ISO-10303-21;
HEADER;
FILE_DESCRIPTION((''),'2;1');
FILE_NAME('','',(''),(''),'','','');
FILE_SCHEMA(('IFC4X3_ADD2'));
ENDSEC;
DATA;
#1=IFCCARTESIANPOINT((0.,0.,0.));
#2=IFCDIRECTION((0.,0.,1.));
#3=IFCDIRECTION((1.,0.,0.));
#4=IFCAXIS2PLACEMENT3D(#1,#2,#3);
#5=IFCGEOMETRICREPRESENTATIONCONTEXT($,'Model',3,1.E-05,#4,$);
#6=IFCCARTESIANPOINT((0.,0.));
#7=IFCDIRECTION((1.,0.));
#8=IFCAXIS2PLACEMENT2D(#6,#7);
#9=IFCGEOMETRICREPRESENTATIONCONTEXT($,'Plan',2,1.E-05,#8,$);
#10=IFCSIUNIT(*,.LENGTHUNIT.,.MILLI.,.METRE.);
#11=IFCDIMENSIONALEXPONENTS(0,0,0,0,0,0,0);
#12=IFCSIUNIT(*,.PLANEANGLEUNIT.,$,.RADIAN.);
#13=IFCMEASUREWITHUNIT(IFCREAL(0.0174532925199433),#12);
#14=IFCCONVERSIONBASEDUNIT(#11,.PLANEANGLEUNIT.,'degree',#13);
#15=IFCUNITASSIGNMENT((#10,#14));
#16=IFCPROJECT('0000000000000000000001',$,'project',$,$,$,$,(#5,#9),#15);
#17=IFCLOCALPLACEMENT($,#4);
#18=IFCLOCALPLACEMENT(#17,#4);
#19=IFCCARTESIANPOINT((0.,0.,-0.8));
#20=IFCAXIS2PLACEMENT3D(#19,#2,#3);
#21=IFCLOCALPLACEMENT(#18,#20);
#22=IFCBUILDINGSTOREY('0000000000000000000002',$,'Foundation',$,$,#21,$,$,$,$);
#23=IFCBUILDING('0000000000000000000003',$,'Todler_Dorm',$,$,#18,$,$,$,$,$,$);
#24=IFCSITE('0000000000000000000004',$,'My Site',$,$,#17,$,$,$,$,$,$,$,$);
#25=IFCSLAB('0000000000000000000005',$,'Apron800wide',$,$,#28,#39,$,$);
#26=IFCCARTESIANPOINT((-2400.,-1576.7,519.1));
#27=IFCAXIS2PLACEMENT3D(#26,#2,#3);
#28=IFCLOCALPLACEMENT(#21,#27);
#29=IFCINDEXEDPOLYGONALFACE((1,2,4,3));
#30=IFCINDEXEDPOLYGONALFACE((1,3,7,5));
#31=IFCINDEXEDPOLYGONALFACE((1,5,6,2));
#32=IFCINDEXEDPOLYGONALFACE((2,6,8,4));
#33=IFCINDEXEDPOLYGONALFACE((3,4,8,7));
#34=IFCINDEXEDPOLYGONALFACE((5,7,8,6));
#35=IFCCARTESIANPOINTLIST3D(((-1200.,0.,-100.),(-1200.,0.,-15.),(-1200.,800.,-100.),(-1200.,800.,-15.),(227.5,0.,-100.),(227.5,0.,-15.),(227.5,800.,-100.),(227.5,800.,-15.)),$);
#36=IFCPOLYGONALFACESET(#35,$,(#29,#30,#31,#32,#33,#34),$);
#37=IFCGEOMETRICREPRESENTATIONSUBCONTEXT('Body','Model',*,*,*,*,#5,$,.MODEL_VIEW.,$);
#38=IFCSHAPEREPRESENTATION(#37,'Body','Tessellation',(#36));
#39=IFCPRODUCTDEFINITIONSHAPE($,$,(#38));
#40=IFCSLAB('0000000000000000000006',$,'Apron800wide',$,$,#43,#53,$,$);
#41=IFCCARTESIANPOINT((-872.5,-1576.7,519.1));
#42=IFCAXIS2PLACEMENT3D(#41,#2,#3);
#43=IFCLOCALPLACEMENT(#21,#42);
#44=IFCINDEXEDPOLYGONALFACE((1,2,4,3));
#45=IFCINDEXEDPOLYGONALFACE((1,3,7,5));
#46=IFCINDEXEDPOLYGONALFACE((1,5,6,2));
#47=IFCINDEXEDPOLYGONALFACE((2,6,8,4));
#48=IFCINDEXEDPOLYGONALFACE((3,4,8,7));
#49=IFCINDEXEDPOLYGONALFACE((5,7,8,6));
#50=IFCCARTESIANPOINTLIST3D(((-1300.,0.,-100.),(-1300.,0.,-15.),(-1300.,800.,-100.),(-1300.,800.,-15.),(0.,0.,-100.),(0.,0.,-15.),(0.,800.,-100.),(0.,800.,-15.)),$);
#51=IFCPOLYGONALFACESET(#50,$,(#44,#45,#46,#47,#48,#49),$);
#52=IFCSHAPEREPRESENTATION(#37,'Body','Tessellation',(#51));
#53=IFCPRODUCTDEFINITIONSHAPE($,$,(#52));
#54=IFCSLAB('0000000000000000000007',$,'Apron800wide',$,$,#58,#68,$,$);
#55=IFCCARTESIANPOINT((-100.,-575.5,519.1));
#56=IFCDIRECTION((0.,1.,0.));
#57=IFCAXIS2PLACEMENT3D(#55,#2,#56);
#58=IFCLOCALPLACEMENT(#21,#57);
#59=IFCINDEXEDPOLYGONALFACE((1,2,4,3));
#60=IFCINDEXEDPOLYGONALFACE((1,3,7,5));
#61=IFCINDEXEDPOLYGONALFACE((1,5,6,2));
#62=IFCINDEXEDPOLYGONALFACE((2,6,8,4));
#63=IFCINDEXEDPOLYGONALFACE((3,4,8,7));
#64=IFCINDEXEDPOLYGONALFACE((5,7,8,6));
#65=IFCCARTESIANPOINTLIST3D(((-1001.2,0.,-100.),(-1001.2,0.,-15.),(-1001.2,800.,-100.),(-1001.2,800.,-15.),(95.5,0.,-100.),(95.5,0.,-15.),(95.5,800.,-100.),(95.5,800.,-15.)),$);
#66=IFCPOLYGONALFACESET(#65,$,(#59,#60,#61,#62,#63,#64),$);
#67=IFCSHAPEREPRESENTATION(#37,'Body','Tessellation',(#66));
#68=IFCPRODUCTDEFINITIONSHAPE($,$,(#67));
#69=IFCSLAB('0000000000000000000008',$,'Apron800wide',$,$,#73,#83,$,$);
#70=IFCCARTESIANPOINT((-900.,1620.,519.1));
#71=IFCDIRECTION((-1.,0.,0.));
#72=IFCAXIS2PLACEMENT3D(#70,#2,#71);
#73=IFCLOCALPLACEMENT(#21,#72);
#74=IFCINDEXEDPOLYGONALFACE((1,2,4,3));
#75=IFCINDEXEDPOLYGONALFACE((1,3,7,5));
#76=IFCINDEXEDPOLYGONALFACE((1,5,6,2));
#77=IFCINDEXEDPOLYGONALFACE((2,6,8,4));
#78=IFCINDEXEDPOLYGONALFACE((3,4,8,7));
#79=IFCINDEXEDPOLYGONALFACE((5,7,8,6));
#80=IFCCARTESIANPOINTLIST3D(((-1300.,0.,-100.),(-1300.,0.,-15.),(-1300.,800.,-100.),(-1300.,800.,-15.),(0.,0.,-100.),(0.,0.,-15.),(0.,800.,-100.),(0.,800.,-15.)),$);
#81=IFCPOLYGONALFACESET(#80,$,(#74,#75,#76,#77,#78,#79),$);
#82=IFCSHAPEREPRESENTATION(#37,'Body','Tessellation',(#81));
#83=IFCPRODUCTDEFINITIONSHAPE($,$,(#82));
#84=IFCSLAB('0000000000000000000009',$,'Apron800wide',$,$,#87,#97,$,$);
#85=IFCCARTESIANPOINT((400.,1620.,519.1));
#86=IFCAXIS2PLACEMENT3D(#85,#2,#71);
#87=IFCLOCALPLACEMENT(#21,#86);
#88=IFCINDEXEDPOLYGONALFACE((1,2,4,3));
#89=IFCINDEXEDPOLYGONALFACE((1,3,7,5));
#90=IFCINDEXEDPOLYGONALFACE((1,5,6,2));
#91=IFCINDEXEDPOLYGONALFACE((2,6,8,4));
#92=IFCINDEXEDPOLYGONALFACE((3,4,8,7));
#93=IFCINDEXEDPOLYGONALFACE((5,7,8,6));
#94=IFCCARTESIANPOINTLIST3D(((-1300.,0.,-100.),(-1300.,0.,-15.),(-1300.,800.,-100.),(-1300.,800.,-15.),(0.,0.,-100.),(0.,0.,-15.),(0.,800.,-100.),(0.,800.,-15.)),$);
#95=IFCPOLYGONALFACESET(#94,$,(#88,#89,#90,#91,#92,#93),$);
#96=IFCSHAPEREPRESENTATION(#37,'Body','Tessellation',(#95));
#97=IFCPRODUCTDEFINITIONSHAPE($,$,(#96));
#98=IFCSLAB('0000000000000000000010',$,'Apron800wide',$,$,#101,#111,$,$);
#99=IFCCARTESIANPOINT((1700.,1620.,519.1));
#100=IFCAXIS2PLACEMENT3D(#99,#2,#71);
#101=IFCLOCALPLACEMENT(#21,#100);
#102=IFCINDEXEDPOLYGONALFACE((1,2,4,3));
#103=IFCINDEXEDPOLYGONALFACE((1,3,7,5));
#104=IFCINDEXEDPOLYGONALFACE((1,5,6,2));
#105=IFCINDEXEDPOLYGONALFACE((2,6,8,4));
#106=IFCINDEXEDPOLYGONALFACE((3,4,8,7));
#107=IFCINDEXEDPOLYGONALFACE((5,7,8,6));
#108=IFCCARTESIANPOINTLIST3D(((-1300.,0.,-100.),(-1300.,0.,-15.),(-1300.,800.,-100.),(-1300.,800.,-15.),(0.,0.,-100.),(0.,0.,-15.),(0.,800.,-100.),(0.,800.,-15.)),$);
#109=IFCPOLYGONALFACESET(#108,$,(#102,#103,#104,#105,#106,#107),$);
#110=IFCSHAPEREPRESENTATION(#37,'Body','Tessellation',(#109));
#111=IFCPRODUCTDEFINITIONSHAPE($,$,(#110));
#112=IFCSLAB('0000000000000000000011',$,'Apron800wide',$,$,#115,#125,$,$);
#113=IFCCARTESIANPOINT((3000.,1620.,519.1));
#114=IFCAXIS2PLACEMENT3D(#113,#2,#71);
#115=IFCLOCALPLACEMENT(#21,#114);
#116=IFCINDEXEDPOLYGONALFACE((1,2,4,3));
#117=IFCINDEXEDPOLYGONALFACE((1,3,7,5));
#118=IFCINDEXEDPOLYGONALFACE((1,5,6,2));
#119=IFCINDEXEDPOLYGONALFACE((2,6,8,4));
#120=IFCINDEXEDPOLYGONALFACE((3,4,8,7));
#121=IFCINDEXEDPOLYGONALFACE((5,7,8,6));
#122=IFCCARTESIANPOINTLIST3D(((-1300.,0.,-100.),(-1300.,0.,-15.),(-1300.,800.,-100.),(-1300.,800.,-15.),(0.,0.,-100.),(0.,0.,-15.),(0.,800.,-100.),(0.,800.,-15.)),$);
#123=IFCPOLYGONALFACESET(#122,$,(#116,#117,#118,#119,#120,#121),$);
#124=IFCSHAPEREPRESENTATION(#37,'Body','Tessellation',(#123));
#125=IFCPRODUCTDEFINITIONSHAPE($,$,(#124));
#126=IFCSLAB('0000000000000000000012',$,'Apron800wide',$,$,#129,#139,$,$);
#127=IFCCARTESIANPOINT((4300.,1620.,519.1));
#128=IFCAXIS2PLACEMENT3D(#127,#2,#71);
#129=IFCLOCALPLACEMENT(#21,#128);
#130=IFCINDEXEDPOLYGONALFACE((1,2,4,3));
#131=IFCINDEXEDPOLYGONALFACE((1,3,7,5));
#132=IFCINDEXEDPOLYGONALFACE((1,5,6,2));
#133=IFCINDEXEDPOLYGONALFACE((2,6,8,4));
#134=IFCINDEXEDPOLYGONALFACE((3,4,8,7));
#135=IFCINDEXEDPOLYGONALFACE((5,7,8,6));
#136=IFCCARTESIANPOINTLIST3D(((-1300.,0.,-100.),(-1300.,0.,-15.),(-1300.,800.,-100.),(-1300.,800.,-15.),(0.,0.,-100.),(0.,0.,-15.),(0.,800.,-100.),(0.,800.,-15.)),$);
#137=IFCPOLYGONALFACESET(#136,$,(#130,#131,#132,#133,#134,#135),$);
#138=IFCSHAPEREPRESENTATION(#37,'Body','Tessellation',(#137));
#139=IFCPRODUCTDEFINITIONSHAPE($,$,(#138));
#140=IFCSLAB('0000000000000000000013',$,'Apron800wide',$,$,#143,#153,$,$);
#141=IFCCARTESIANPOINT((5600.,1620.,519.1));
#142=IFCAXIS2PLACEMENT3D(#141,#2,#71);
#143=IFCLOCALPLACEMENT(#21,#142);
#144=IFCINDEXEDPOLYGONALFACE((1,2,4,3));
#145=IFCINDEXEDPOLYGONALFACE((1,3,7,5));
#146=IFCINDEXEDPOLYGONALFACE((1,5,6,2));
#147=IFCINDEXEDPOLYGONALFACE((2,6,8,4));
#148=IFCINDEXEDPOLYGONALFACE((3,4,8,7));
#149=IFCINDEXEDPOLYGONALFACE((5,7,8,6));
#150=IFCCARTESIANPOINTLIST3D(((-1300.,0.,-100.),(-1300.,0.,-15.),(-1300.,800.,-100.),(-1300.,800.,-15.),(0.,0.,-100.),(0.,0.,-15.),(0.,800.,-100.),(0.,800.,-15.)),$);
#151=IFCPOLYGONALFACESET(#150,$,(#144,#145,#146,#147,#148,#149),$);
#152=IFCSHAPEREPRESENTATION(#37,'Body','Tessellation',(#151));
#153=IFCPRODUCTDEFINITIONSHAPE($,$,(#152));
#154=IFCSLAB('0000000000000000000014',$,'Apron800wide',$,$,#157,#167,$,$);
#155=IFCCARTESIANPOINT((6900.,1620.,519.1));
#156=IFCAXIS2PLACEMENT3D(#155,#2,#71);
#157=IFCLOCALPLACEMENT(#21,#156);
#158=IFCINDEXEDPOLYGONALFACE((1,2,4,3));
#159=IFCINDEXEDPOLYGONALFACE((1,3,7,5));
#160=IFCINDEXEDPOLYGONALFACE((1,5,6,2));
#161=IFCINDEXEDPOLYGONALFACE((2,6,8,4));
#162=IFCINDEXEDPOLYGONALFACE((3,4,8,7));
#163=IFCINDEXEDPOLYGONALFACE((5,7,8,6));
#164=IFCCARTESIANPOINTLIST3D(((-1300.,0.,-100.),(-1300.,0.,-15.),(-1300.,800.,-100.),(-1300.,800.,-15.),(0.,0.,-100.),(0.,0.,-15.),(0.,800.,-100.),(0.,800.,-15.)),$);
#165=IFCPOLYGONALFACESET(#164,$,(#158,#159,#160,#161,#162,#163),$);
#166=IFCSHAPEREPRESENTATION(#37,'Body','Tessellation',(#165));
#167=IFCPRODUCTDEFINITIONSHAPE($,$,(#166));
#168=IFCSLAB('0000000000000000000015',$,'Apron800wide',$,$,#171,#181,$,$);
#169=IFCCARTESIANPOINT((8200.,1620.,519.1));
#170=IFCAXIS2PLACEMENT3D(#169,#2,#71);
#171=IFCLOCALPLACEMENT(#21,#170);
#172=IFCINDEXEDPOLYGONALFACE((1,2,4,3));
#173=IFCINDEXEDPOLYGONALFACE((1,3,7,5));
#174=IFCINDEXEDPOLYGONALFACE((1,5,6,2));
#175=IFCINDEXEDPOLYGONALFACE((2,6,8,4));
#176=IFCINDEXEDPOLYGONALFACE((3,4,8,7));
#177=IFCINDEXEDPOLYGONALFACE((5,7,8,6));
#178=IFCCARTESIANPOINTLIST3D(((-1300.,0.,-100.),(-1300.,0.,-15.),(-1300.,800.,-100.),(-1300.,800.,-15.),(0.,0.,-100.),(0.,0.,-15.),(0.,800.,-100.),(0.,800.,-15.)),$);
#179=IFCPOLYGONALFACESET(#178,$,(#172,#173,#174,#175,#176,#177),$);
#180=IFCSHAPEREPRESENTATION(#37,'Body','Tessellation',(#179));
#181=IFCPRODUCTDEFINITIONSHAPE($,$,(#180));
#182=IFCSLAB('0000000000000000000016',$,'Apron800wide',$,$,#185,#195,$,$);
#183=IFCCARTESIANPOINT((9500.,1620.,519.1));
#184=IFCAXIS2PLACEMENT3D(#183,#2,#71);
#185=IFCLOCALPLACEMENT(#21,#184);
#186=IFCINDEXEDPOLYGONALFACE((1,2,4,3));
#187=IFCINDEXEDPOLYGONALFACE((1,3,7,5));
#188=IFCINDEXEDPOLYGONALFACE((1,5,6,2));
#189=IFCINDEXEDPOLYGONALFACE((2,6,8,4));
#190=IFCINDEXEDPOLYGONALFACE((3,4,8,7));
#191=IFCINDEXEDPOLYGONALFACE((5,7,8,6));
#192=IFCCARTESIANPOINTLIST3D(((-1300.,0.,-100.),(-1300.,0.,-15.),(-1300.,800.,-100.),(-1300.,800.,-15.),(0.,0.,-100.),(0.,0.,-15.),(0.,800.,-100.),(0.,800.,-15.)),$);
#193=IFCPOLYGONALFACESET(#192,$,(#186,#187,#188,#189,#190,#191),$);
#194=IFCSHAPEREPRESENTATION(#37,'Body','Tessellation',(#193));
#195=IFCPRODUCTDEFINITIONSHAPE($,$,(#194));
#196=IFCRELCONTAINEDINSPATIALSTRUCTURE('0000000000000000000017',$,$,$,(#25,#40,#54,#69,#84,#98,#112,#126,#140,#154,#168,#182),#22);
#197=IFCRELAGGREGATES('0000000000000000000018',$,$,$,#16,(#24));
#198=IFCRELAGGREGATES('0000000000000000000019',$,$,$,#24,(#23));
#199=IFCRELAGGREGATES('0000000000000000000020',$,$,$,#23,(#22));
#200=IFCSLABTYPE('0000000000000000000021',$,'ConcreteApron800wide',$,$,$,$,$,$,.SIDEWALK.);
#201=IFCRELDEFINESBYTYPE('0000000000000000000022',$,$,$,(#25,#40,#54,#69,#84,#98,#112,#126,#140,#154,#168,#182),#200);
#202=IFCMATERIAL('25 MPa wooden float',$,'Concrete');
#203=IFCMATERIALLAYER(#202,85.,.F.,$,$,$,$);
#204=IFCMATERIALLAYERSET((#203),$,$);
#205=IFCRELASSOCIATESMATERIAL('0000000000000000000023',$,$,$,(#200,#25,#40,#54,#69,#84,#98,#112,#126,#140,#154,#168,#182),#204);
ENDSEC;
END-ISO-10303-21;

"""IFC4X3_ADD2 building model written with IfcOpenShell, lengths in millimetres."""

from ifc_helpers import new_model, entity, si_unit, converted_unit, frame, origin_with_axes, origin_2d_with_axis, place, context, subcontext, project, spatial, indexed_curve, outline, extrude, material, layer, layer_set, layer_usage, type_object, element, save


model = new_model("IFC4X3_ADD2")

# Units and contexts
model_context = context("Model", 3, precision=1e-05, world=origin_with_axes())
plan_context = context("Plan", 2, precision=1e-05, world=origin_2d_with_axis())
body_context = subcontext(model_context, "Body", "Model", "MODEL_VIEW")
ifc_project = project(units=[si_unit("LENGTHUNIT", "METRE", prefix="MILLI"), converted_unit("PLANEANGLEUNIT", "degree", entity("IfcReal", 0.0174532925199433), si_unit("PLANEANGLEUNIT", "RADIAN"), dimensions=[0, 0, 0, 0, 0, 0, 0])], contexts=[model_context, plan_context])

# Site, building, storey
site_placement = place(None, origin_with_axes())
site = spatial("IfcSite", under=ifc_project, at=site_placement, Name="My Site")
building_placement = place(site_placement, origin_with_axes())
building = spatial("IfcBuilding", under=site, at=building_placement, Name="Todler_Dorm")
storey_placement = place(building_placement, frame((0.0, 0.0, -0.8), z_axis=(0.0, 0.0, 1.0), x_axis=(1.0, 0.0, 0.0)))
storey = spatial("IfcBuildingStorey", under=building, at=storey_placement, Name="Foundation")

# Slabs
ifc_material_1 = material(Name="25 MPa wooden float", Category="Concrete")
ifc_layer_1 = layer(ifc_material_1, 85.0, ventilated=False)
ifc_layer_set_1 = layer_set([ifc_layer_1])
ifc_layer_usage_1 = layer_usage(ifc_layer_set_1, "AXIS3", "POSITIVE", -100.0)
slab_type = type_object("IfcSlabType", Name="ConcreteApron800wide", PredefinedType="SIDEWALK", material=ifc_layer_set_1)
slab_1_placement = place(storey_placement, frame((-2400.0, -1576.7, 519.1), z_axis=(0.0, 0.0, 1.0), x_axis=(1.0, 0.0, 0.0)))
element("IfcSlab", 1, at=slab_1_placement, inside=storey, type_object=slab_type, material=ifc_layer_usage_1, Name="Apron800wide", context=body_context, shape_type="SweptSolid", body=[
    extrude(outline(indexed_curve([(-1200.0, 0.0), (-1200.0, 800.0), (227.5, 800.0), (227.5, 0.0), (-1200.0, 0.0)])), frame((0.0, 0.0, -100.0), z_axis=(0.0, 0.0, 1.0), x_axis=(1.0, 0.0, 0.0)), (0.0, 0.0, 1.0), 85.0),
])
ifc_layer_usage_2 = layer_usage(ifc_layer_set_1, "AXIS3", "POSITIVE", -100.0)
slab_2_placement = place(storey_placement, frame((-872.5, -1576.7, 519.1), z_axis=(0.0, 0.0, 1.0), x_axis=(1.0, 0.0, 0.0)))
element("IfcSlab", 2, at=slab_2_placement, inside=storey, type_object=slab_type, material=ifc_layer_usage_2, Name="Apron800wide", context=body_context, shape_type="SweptSolid", body=[
    extrude(outline(indexed_curve([(-1300.0, 0.0), (-1300.0, 800.0), (0.0, 800.0), (0.0, 0.0), (-1300.0, 0.0)])), frame((0.0, 0.0, -100.0), z_axis=(0.0, 0.0, 1.0), x_axis=(1.0, 0.0, 0.0)), (0.0, 0.0, 1.0), 85.0),
])
ifc_layer_usage_3 = layer_usage(ifc_layer_set_1, "AXIS3", "POSITIVE", -100.0)
slab_3_placement = place(storey_placement, frame((-100.0, -575.5, 519.1), z_axis=(0.0, 0.0, 1.0), x_axis=(0.0, 1.0, 0.0)))
element("IfcSlab", 3, at=slab_3_placement, inside=storey, type_object=slab_type, material=ifc_layer_usage_3, Name="Apron800wide", context=body_context, shape_type="SweptSolid", body=[
    extrude(outline(indexed_curve([(95.5, 0.0), (95.5, 800.0), (-1001.2, 800.0), (-1001.2, 0.0), (95.5, 0.0)])), frame((0.0, 0.0, -100.0), z_axis=(0.0, 0.0, 1.0), x_axis=(1.0, 0.0, 0.0)), (0.0, 0.0, 1.0), 85.0),
])
ifc_layer_usage_4 = layer_usage(ifc_layer_set_1, "AXIS3", "POSITIVE", -100.0)
slab_4_placement = place(storey_placement, frame((-900.0, 1620.0, 519.1), z_axis=(0.0, 0.0, 1.0), x_axis=(-1.0, 0.0, 0.0)))
element("IfcSlab", 4, at=slab_4_placement, inside=storey, type_object=slab_type, material=ifc_layer_usage_4, Name="Apron800wide", context=body_context, shape_type="SweptSolid", body=[
    extrude(outline(indexed_curve([(0.0, 0.0), (0.0, 800.0), (-1300.0, 800.0), (-1300.0, 0.0), (0.0, 0.0)])), frame((0.0, 0.0, -100.0), z_axis=(0.0, 0.0, 1.0), x_axis=(1.0, 0.0, 0.0)), (0.0, 0.0, 1.0), 85.0),
])
ifc_layer_usage_5 = layer_usage(ifc_layer_set_1, "AXIS3", "POSITIVE", -100.0)
slab_5_placement = place(storey_placement, frame((400.0, 1620.0, 519.1), z_axis=(0.0, 0.0, 1.0), x_axis=(-1.0, 0.0, 0.0)))
element("IfcSlab", 5, at=slab_5_placement, inside=storey, type_object=slab_type, material=ifc_layer_usage_5, Name="Apron800wide", context=body_context, shape_type="SweptSolid", body=[
    extrude(outline(indexed_curve([(0.0, 0.0), (0.0, 800.0), (-1300.0, 800.0), (-1300.0, 0.0), (0.0, 0.0)])), frame((0.0, 0.0, -100.0), z_axis=(0.0, 0.0, 1.0), x_axis=(1.0, 0.0, 0.0)), (0.0, 0.0, 1.0), 85.0),
])
ifc_layer_usage_6 = layer_usage(ifc_layer_set_1, "AXIS3", "POSITIVE", -100.0)
slab_6_placement = place(storey_placement, frame((1700.0, 1620.0, 519.1), z_axis=(0.0, 0.0, 1.0), x_axis=(-1.0, 0.0, 0.0)))
element("IfcSlab", 6, at=slab_6_placement, inside=storey, type_object=slab_type, material=ifc_layer_usage_6, Name="Apron800wide", context=body_context, shape_type="SweptSolid", body=[
    extrude(outline(indexed_curve([(0.0, 0.0), (0.0, 800.0), (-1300.0, 800.0), (-1300.0, 0.0), (0.0, 0.0)])), frame((0.0, 0.0, -100.0), z_axis=(0.0, 0.0, 1.0), x_axis=(1.0, 0.0, 0.0)), (0.0, 0.0, 1.0), 85.0),
])
ifc_layer_usage_7 = layer_usage(ifc_layer_set_1, "AXIS3", "POSITIVE", -100.0)
slab_7_placement = place(storey_placement, frame((3000.0, 1620.0, 519.1), z_axis=(0.0, 0.0, 1.0), x_axis=(-1.0, 0.0, 0.0)))
element("IfcSlab", 7, at=slab_7_placement, inside=storey, type_object=slab_type, material=ifc_layer_usage_7, Name="Apron800wide", context=body_context, shape_type="SweptSolid", body=[
    extrude(outline(indexed_curve([(0.0, 0.0), (0.0, 800.0), (-1300.0, 800.0), (-1300.0, 0.0), (0.0, 0.0)])), frame((0.0, 0.0, -100.0), z_axis=(0.0, 0.0, 1.0), x_axis=(1.0, 0.0, 0.0)), (0.0, 0.0, 1.0), 85.0),
])
ifc_layer_usage_8 = layer_usage(ifc_layer_set_1, "AXIS3", "POSITIVE", -100.0)
slab_8_placement = place(storey_placement, frame((4300.0, 1620.0, 519.1), z_axis=(0.0, 0.0, 1.0), x_axis=(-1.0, 0.0, 0.0)))
element("IfcSlab", 8, at=slab_8_placement, inside=storey, type_object=slab_type, material=ifc_layer_usage_8, Name="Apron800wide", context=body_context, shape_type="SweptSolid", body=[
    extrude(outline(indexed_curve([(0.0, 0.0), (0.0, 800.0), (-1300.0, 800.0), (-1300.0, 0.0), (0.0, 0.0)])), frame((0.0, 0.0, -100.0), z_axis=(0.0, 0.0, 1.0), x_axis=(1.0, 0.0, 0.0)), (0.0, 0.0, 1.0), 85.0),
])
ifc_layer_usage_9 = layer_usage(ifc_layer_set_1, "AXIS3", "POSITIVE", -100.0)
slab_9_placement = place(storey_placement, frame((5600.0, 1620.0, 519.1), z_axis=(0.0, 0.0, 1.0), x_axis=(-1.0, 0.0, 0.0)))
element("IfcSlab", 9, at=slab_9_placement, inside=storey, type_object=slab_type, material=ifc_layer_usage_9, Name="Apron800wide", context=body_context, shape_type="SweptSolid", body=[
    extrude(outline(indexed_curve([(0.0, 0.0), (0.0, 800.0), (-1300.0, 800.0), (-1300.0, 0.0), (0.0, 0.0)])), frame((0.0, 0.0, -100.0), z_axis=(0.0, 0.0, 1.0), x_axis=(1.0, 0.0, 0.0)), (0.0, 0.0, 1.0), 85.0),
])
ifc_layer_usage_10 = layer_usage(ifc_layer_set_1, "AXIS3", "POSITIVE", -100.0)
slab_10_placement = place(storey_placement, frame((6900.0, 1620.0, 519.1), z_axis=(0.0, 0.0, 1.0), x_axis=(-1.0, 0.0, 0.0)))
element("IfcSlab", 10, at=slab_10_placement, inside=storey, type_object=slab_type, material=ifc_layer_usage_10, Name="Apron800wide", context=body_context, shape_type="SweptSolid", body=[
    extrude(outline(indexed_curve([(0.0, 0.0), (0.0, 800.0), (-1300.0, 800.0), (-1300.0, 0.0), (0.0, 0.0)])), frame((0.0, 0.0, -100.0), z_axis=(0.0, 0.0, 1.0), x_axis=(1.0, 0.0, 0.0)), (0.0, 0.0, 1.0), 85.0),
])
ifc_layer_usage_11 = layer_usage(ifc_layer_set_1, "AXIS3", "POSITIVE", -100.0)
slab_11_placement = place(storey_placement, frame((8200.0, 1620.0, 519.1), z_axis=(0.0, 0.0, 1.0), x_axis=(-1.0, 0.0, 0.0)))
element("IfcSlab", 11, at=slab_11_placement, inside=storey, type_object=slab_type, material=ifc_layer_usage_11, Name="Apron800wide", context=body_context, shape_type="SweptSolid", body=[
    extrude(outline(indexed_curve([(0.0, 0.0), (0.0, 800.0), (-1300.0, 800.0), (-1300.0, 0.0), (0.0, 0.0)])), frame((0.0, 0.0, -100.0), z_axis=(0.0, 0.0, 1.0), x_axis=(1.0, 0.0, 0.0)), (0.0, 0.0, 1.0), 85.0),
])
ifc_layer_usage_12 = layer_usage(ifc_layer_set_1, "AXIS3", "POSITIVE", -100.0)
slab_12_placement = place(storey_placement, frame((9500.0, 1620.0, 519.1), z_axis=(0.0, 0.0, 1.0), x_axis=(-1.0, 0.0, 0.0)))
element("IfcSlab", 12, at=slab_12_placement, inside=storey, type_object=slab_type, material=ifc_layer_usage_12, Name="Apron800wide", context=body_context, shape_type="SweptSolid", body=[
    extrude(outline(indexed_curve([(0.0, 0.0), (0.0, 800.0), (-1300.0, 800.0), (-1300.0, 0.0), (0.0, 0.0)])), frame((0.0, 0.0, -100.0), z_axis=(0.0, 0.0, 1.0), x_axis=(1.0, 0.0, 0.0)), (0.0, 0.0, 1.0), 85.0),
])

save(model, "model.ifc")
